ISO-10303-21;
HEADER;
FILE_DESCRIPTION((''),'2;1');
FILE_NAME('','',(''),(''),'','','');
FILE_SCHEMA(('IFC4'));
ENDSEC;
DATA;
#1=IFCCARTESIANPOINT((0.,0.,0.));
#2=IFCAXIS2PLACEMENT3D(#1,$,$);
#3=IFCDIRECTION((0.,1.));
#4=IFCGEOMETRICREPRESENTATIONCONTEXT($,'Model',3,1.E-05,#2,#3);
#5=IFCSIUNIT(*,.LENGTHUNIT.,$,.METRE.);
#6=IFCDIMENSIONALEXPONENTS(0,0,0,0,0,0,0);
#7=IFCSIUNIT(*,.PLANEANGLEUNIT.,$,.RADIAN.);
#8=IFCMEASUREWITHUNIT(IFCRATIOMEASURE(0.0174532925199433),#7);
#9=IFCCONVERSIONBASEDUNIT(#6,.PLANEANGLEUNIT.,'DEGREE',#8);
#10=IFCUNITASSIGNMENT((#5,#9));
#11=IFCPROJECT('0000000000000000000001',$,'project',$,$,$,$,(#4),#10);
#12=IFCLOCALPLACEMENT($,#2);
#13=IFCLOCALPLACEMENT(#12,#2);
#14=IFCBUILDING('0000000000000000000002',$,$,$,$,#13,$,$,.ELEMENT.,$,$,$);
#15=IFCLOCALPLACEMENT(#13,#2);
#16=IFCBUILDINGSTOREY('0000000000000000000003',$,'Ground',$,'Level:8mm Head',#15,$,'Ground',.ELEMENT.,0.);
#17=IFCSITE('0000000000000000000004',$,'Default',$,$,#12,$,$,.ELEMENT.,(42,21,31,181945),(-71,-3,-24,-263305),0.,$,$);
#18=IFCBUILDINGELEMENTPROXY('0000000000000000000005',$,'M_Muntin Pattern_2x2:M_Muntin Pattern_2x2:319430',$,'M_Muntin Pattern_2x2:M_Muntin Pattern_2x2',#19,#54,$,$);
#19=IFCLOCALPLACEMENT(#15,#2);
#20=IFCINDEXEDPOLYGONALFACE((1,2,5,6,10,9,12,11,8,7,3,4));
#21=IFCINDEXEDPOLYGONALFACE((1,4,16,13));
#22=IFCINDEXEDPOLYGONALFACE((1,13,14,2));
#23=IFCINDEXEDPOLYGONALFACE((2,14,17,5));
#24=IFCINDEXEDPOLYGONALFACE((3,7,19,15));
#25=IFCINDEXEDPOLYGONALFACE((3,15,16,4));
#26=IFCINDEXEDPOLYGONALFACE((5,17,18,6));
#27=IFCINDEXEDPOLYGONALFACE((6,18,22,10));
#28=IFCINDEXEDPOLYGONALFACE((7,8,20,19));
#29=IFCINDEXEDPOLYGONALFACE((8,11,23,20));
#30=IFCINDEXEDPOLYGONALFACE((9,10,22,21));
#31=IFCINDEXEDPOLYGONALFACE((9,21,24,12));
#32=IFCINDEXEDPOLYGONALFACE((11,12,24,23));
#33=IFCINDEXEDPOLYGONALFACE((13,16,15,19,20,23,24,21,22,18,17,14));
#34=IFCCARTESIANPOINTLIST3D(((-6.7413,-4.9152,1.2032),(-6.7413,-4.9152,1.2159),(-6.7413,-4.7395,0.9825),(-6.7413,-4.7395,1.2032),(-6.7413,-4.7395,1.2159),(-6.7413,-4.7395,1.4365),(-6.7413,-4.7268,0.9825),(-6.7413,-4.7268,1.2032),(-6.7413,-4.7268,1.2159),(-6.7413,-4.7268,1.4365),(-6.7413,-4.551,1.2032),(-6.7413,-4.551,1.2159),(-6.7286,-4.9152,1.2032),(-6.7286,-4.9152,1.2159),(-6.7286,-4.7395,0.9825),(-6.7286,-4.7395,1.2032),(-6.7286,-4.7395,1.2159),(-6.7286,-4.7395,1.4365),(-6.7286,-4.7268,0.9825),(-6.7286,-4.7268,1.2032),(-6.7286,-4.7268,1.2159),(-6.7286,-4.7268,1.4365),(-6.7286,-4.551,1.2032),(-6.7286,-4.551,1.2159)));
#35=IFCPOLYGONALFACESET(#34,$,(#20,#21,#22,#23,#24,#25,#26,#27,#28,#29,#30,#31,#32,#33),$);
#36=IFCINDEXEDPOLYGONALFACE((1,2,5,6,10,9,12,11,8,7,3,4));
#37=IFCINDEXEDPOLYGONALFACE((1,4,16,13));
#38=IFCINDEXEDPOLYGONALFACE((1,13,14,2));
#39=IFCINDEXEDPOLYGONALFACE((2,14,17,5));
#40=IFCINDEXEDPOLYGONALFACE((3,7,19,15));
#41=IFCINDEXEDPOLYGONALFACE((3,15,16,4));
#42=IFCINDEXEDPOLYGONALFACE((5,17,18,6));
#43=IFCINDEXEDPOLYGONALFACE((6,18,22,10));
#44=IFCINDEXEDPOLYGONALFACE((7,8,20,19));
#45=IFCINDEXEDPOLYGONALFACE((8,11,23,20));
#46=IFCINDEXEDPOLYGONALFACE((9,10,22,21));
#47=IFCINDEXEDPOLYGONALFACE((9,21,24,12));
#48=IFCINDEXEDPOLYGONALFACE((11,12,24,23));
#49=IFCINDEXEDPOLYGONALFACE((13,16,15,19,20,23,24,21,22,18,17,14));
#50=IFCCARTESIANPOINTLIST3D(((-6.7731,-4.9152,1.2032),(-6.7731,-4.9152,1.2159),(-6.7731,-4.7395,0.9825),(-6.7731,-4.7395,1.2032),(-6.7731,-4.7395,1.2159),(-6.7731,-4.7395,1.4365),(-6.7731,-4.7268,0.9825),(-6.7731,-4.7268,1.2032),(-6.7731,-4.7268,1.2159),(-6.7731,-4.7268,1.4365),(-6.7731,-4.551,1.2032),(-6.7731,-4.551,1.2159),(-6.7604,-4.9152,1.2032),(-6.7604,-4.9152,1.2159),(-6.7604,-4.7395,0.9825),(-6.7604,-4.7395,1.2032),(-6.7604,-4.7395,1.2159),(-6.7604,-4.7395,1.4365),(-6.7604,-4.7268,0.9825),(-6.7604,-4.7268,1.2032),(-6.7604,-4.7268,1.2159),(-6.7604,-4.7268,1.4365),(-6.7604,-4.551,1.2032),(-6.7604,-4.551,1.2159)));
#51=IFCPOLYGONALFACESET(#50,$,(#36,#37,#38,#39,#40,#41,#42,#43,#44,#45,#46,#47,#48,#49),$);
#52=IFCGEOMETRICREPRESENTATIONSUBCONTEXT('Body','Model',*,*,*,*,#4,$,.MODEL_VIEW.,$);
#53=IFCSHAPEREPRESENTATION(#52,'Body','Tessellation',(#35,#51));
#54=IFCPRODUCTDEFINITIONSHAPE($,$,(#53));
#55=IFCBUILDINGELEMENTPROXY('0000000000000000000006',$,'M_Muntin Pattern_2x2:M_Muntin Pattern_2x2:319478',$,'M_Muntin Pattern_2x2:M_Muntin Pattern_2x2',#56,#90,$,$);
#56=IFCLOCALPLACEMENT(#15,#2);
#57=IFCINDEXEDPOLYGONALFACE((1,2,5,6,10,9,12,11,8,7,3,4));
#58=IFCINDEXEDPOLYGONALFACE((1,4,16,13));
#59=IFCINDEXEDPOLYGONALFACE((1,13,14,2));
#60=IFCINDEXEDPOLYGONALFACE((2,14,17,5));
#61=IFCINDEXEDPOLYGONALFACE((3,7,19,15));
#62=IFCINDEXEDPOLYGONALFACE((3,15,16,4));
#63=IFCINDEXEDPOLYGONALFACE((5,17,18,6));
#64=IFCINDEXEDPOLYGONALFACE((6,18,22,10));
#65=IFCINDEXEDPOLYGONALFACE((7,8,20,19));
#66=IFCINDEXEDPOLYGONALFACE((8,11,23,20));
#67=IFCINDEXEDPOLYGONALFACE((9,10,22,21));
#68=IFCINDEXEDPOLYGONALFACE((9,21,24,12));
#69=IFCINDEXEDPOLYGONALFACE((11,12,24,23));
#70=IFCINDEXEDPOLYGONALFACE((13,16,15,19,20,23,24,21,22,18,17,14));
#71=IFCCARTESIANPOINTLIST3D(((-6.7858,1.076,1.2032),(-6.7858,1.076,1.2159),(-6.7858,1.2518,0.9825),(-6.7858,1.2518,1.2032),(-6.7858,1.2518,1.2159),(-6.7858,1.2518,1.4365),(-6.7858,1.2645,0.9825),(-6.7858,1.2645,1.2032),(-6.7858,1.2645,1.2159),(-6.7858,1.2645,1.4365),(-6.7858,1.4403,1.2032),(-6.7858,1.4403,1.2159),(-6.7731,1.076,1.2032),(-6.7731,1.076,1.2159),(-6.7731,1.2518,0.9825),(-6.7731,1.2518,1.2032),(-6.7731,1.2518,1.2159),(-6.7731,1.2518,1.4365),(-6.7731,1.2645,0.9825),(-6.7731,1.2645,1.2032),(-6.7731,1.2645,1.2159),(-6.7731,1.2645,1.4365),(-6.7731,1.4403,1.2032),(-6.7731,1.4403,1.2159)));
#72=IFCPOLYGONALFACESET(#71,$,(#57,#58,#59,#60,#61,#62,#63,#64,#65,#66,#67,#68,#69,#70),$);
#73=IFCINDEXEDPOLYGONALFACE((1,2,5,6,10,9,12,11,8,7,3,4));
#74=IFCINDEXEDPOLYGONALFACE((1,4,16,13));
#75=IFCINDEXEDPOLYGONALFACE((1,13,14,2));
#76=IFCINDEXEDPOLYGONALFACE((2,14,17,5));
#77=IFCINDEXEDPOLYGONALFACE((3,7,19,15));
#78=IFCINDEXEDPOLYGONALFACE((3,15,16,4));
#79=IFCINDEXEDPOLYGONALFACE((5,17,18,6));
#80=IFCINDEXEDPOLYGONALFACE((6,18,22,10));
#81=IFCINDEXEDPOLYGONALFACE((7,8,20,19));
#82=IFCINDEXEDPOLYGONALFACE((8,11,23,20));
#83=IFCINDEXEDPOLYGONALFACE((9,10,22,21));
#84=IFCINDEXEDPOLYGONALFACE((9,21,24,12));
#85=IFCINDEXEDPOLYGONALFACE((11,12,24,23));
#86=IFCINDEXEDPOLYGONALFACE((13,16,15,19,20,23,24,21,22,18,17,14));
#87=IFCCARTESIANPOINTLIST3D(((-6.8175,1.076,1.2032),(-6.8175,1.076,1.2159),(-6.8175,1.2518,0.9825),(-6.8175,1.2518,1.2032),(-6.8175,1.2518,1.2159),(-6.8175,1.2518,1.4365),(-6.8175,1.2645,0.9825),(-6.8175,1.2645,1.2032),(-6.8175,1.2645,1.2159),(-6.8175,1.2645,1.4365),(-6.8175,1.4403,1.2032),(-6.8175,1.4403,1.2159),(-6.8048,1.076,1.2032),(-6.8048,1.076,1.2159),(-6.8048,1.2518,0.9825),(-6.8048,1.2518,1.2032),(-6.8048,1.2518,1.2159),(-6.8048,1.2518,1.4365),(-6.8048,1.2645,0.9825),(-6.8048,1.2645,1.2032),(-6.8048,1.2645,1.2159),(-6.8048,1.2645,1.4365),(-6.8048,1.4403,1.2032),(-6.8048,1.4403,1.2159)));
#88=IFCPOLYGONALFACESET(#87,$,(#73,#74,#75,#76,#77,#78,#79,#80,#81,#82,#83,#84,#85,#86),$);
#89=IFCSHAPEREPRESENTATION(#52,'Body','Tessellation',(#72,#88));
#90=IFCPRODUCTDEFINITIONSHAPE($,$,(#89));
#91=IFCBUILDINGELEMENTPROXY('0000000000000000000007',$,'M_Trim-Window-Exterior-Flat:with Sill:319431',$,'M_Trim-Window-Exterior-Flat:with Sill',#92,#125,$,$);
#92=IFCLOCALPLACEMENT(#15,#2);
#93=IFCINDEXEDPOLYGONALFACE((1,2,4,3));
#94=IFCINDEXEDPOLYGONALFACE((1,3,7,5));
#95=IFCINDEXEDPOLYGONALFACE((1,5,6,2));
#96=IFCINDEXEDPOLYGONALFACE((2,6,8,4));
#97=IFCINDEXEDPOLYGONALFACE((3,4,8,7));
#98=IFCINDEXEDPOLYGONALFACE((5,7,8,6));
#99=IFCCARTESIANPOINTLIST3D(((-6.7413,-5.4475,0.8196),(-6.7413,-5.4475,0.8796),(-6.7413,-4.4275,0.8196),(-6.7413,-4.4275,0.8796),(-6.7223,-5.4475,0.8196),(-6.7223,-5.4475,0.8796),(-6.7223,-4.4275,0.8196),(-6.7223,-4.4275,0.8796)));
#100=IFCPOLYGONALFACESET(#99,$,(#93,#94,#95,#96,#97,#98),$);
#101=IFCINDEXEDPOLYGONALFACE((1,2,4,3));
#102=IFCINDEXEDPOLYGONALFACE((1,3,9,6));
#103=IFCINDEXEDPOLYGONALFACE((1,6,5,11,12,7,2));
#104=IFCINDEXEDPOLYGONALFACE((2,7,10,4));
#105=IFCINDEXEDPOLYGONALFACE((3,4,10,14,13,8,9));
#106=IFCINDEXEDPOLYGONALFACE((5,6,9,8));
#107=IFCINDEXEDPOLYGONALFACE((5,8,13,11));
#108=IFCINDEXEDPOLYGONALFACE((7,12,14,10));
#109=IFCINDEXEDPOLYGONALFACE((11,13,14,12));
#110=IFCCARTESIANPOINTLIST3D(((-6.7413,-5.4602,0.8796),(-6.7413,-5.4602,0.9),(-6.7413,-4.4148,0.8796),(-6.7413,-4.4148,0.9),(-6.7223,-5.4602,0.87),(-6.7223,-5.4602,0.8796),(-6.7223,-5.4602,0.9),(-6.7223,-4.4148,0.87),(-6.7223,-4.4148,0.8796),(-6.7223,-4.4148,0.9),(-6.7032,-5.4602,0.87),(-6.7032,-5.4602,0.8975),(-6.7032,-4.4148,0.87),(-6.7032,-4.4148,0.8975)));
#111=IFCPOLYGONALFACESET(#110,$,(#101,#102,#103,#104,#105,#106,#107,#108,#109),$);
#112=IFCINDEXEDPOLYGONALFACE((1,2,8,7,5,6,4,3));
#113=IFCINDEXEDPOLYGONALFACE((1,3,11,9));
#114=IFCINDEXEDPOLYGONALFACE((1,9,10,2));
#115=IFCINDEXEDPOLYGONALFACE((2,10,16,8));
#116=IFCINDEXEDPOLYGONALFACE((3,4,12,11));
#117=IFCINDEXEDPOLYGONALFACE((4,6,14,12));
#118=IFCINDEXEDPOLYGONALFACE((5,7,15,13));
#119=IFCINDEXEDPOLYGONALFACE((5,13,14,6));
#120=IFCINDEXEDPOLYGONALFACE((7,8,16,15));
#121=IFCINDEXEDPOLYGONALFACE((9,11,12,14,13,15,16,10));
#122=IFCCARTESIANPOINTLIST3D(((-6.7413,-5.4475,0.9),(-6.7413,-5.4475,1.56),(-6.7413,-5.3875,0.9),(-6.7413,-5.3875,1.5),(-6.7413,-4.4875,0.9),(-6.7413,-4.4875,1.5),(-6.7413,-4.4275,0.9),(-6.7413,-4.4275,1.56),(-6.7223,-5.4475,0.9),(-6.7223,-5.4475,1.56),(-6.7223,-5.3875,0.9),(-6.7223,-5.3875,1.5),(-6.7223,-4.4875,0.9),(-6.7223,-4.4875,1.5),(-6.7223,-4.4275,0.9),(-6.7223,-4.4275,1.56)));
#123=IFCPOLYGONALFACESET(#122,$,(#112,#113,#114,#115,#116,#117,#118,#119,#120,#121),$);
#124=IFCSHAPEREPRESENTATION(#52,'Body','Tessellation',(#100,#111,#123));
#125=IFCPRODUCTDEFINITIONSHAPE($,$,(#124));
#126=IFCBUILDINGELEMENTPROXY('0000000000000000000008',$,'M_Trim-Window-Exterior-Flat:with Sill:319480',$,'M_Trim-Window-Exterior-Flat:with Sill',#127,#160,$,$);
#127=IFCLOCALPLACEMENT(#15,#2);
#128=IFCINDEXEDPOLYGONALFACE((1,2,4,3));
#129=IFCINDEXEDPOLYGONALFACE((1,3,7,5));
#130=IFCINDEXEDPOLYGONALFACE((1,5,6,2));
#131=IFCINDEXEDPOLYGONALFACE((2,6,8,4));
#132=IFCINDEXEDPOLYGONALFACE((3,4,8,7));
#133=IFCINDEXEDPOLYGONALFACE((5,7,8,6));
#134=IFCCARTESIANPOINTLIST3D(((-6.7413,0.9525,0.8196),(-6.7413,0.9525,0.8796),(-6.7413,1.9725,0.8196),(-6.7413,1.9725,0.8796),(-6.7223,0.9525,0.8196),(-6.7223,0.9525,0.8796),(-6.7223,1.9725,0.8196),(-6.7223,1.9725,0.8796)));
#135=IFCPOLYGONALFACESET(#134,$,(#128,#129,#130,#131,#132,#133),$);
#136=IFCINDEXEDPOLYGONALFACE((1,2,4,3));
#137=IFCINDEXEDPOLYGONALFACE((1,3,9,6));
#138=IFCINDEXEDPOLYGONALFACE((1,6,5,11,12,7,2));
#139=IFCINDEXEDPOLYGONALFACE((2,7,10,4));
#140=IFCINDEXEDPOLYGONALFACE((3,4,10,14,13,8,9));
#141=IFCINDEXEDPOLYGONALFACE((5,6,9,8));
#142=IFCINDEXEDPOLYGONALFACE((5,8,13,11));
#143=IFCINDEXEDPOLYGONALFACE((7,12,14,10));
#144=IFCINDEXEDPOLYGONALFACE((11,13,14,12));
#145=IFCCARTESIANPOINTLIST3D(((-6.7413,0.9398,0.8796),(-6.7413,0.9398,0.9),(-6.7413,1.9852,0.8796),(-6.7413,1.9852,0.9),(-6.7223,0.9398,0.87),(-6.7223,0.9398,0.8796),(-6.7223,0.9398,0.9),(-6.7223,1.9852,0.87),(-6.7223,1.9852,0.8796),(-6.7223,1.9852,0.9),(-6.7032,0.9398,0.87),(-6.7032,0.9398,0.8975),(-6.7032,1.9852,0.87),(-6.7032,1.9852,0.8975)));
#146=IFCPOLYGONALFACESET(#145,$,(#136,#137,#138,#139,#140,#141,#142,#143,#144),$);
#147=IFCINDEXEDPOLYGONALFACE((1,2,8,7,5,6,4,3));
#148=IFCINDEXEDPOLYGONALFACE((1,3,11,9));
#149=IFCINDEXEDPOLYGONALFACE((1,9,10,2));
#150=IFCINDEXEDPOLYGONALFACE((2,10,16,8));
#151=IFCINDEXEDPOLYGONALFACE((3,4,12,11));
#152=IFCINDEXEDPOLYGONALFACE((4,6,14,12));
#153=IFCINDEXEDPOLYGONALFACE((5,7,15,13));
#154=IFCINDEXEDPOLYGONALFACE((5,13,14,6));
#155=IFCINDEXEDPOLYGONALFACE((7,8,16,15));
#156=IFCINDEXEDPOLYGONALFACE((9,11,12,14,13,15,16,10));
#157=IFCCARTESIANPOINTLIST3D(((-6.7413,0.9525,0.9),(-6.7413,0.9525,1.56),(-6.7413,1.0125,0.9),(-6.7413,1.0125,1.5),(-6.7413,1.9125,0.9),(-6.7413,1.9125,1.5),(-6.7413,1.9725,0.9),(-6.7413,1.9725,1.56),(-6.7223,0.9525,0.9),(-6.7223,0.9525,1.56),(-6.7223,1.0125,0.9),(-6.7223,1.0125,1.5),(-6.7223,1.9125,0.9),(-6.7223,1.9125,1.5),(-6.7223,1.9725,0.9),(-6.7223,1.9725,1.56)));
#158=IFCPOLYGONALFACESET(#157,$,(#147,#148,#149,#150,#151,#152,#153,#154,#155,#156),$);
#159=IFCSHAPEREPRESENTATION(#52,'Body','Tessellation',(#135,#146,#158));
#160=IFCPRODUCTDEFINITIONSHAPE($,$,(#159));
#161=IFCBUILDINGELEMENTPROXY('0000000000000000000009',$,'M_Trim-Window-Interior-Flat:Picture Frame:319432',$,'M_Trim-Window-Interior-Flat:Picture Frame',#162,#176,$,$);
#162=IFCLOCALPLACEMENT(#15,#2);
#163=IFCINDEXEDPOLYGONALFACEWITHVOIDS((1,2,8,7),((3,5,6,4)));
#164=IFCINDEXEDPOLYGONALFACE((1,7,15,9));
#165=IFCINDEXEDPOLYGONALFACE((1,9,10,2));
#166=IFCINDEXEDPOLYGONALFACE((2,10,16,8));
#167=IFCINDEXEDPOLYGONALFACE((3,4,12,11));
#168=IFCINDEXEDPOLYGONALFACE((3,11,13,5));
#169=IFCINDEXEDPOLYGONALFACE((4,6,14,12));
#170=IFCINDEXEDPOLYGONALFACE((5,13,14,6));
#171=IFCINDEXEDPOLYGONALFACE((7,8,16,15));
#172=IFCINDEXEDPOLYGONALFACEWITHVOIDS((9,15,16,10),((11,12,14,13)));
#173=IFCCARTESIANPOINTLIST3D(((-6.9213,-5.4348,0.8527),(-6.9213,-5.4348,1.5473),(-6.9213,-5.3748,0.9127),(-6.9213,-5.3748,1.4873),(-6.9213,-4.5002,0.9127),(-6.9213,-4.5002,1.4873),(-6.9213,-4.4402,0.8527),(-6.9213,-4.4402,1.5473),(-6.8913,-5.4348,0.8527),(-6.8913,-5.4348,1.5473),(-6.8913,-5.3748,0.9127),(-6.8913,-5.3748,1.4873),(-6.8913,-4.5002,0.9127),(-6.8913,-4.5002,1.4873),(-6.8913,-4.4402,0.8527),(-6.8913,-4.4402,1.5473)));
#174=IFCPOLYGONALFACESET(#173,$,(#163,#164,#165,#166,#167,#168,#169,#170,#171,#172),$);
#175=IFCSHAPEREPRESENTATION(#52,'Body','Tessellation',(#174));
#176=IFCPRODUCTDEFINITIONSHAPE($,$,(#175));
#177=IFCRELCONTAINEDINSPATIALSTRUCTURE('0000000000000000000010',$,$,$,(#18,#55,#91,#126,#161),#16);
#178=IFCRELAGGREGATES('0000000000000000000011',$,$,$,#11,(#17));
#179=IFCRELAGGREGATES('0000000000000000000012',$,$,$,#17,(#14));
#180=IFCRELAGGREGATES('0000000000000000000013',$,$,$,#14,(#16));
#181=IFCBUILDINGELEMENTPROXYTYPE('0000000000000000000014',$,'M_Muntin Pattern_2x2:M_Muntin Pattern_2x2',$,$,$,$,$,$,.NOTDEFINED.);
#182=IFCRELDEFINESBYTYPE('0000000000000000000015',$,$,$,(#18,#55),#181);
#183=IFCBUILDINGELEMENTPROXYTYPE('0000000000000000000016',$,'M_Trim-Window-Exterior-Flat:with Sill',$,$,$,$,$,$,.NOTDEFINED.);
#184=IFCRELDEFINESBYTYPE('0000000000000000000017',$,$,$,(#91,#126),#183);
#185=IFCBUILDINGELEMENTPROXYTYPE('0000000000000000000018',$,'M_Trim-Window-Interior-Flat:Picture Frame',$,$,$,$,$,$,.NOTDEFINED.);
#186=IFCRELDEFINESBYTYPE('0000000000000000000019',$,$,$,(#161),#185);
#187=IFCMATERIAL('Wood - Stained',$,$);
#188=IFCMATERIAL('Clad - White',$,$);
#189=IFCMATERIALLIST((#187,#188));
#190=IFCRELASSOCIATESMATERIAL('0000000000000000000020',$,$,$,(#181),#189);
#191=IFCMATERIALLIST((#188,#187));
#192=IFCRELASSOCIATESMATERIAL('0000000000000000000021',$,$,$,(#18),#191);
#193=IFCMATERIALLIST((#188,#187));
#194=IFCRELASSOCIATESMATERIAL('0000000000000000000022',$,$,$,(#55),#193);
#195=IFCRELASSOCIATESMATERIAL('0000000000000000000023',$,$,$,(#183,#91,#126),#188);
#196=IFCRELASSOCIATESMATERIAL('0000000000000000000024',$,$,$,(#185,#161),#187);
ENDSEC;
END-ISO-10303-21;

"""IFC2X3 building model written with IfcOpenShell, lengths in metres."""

from ifc_helpers import new_model, entity, si_unit, converted_unit, direction, frame, frame_2d, origin, place, context, subcontext, project, spatial, polyline, rectangle, outline, extrude, source, transform, mapped, material, material_list, type_object, type_shapes, element, save


model = new_model("IFC2X3")

# Units and contexts
model_context = context("Model", 3, precision=1e-05, world=origin(), true_north=direction((0.0, 1.0)))
body_context = subcontext(model_context, "Body", "Model", "MODEL_VIEW")
ifc_project = project(units=[si_unit("LENGTHUNIT", "METRE"), converted_unit("PLANEANGLEUNIT", "DEGREE", entity("IfcRatioMeasure", 0.0174532925199433), si_unit("PLANEANGLEUNIT", "RADIAN"), dimensions=[0, 0, 0, 0, 0, 0, 0])], contexts=[model_context])

# Site, building, storey
site_placement = place(None, origin())
site = spatial("IfcSite", under=ifc_project, at=site_placement, Name="Default", CompositionType="ELEMENT", RefLatitude=(42, 21, 31, 181945), RefLongitude=(-71, -3, -24, -263305), RefElevation=0.0)
building_placement = place(site_placement, origin())
building = spatial("IfcBuilding", under=site, at=building_placement, CompositionType="ELEMENT")
storey_placement = place(building_placement, origin())
storey = spatial("IfcBuildingStorey", under=building, at=storey_placement, Name="Ground", ObjectType="Level:8mm Head", LongName="Ground", CompositionType="ELEMENT", Elevation=0.0)

# Building element proxies
ifc_material_1 = material(Name="Clad - White")
ifc_material_2 = material(Name="Wood - Stained")
ifc_material_list_1 = material_list([ifc_material_2, ifc_material_1])
building_element_proxy_type_1 = type_object("IfcBuildingElementProxyType", Name="M_Muntin Pattern_2x2:M_Muntin Pattern_2x2", PredefinedType="NOTDEFINED", material=ifc_material_list_1)
shared_shape_1 = source(origin(), body_context, "Body", "SweptSolid", [
    extrude(outline(polyline([(0.0064, -0.0064), (0.227, -0.0064), (0.227, 0.0063), (0.0064, 0.0063), (0.0064, 0.1821), (-0.0063, 0.1821), (-0.0063, 0.0063), (-0.227, 0.0063), (-0.227, -0.0064), (-0.0063, -0.0064), (-0.0063, -0.1821), (0.0064, -0.1821), (0.0064, -0.0064)])), frame((0.0, 0.0095, 0.227), z_axis=(0.0, 1.0, 0.0), x_axis=(0.0, 0.0, 1.0)), (0.0, 0.0, 1.0), 0.0127),
    extrude(outline(polyline([(0.0064, -0.0064), (0.227, -0.0064), (0.227, 0.0063), (0.0064, 0.0063), (0.0064, 0.1821), (-0.0063, 0.1821), (-0.0063, 0.0063), (-0.227, 0.0063), (-0.227, -0.0064), (-0.0063, -0.0064), (-0.0063, -0.1821), (0.0064, -0.1821), (0.0064, -0.0064)])), frame((0.0, -0.0222, 0.227), z_axis=(0.0, 1.0, 0.0), x_axis=(0.0, 0.0, 1.0)), (0.0, 0.0, 1.0), 0.0127),
])
type_shapes(building_element_proxy_type_1, [shared_shape_1])
ifc_material_list_2 = material_list([ifc_material_1, ifc_material_2])
proxy_1_placement = place(storey_placement, frame((-6.7509, -4.7331, 0.9825), z_axis=(0.0, 0.0, 1.0), x_axis=(0.0, -1.0, 0.0)))
element("IfcBuildingElementProxy", 1, at=proxy_1_placement, inside=storey, type_object=building_element_proxy_type_1, material=ifc_material_list_2, Name="M_Muntin Pattern_2x2:M_Muntin Pattern_2x2:319430", ObjectType="M_Muntin Pattern_2x2:M_Muntin Pattern_2x2", context=body_context, shape_type="MappedRepresentation", body=[
    mapped(shared_shape_1, transform((0.0, 0.0, 0.0), scale=1.0)),
])
ifc_material_list_3 = material_list([ifc_material_1, ifc_material_2])
proxy_2_placement = place(storey_placement, frame((-6.7953, 1.2582, 0.9825), z_axis=(0.0, 0.0, 1.0), x_axis=(0.0, -1.0, 0.0)))
element("IfcBuildingElementProxy", 2, at=proxy_2_placement, inside=storey, type_object=building_element_proxy_type_1, material=ifc_material_list_3, Name="M_Muntin Pattern_2x2:M_Muntin Pattern_2x2:319478", ObjectType="M_Muntin Pattern_2x2:M_Muntin Pattern_2x2", context=body_context, shape_type="MappedRepresentation", body=[
    mapped(shared_shape_1, transform((0.0, 0.0, 0.0), scale=1.0)),
])
building_element_proxy_type_2 = type_object("IfcBuildingElementProxyType", Name="M_Trim-Window-Exterior-Flat:with Sill", PredefinedType="NOTDEFINED", material=ifc_material_1)
shared_shape_2 = source(origin(), body_context, "Body", "SweptSolid", [
    extrude(rectangle(XDim=1.02, YDim=0.06, at=frame_2d((0.0, 0.0), x_axis=(1.0, 0.0))), frame((0.0, -0.6504, 0.0), z_axis=(0.0, 0.0, 1.0), x_axis=(-1.0, 0.0, 0.0)), (0.0, 0.0, 1.0), 0.0191),
    extrude(outline(polyline([(-0.019, -0.0152), (0.0, -0.0152), (0.0, -0.0057), (0.019, -0.0057), (0.019, 0.0148), (0.0, 0.0148), (-0.019, 0.0123), (-0.019, -0.0152)])), frame((-0.5227, -0.6148, 0.019), z_axis=(1.0, 0.0, 0.0), x_axis=(0.0, 0.0, -1.0)), (0.0, 0.0, 1.0), 1.0454),
    extrude(outline(polyline([(-0.345, -0.51), (0.315, -0.51), (0.315, -0.45), (-0.285, -0.45), (-0.285, 0.45), (0.315, 0.45), (0.315, 0.51), (-0.345, 0.51), (-0.345, -0.51)])), frame((0.0, -0.285, 0.0), z_axis=(0.0, 0.0, 1.0), x_axis=(0.0, -1.0, 0.0)), (0.0, 0.0, 1.0), 0.0191),
])
type_shapes(building_element_proxy_type_2, [shared_shape_2])
for number, where, z_axis, x_axis, name in (
    (3, (-6.7413, -4.9375, 1.5), (1.0, 0.0, 0.0), (0.0, 1.0, 0.0), "M_Trim-Window-Exterior-Flat:with Sill:319431"),
    (4, (-6.7413, 1.4625, 1.5), (1.0, 0.0, 0.0), (0.0, 1.0, 0.0), "M_Trim-Window-Exterior-Flat:with Sill:319480"),
):
    element("IfcBuildingElementProxy", number, at=place(storey_placement, frame(where, z_axis=z_axis, x_axis=x_axis)), inside=storey, type_object=building_element_proxy_type_2, material=ifc_material_1, Name=name, ObjectType="M_Trim-Window-Exterior-Flat:with Sill", context=body_context, shape_type="MappedRepresentation", body=[
        mapped(shared_shape_2, transform((0.0, 0.0, 0.0), scale=1.0)),
    ])
building_element_proxy_type_3 = type_object("IfcBuildingElementProxyType", Name="M_Trim-Window-Interior-Flat:Picture Frame", PredefinedType="NOTDEFINED", material=ifc_material_2)
shared_shape_3 = source(origin(), body_context, "Body", "SweptSolid", [
    extrude(outline(polyline([(-0.4973, -0.3473), (0.4973, -0.3473), (0.4973, 0.3473), (-0.4973, 0.3473), (-0.4973, -0.3473)]), holes=[polyline([(-0.4373, -0.2873), (-0.4373, 0.2873), (0.4373, 0.2873), (0.4373, -0.2873), (-0.4373, -0.2873)])]), frame((0.0, -0.3, 0.0), z_axis=(0.0, 0.0, 1.0), x_axis=(-1.0, 0.0, 0.0)), (0.0, 0.0, 1.0), 0.03),
])
type_shapes(building_element_proxy_type_3, [shared_shape_3])
proxy_3_placement = place(storey_placement, frame((-6.8913, -4.9375, 1.5), z_axis=(-1.0, 0.0, 0.0), x_axis=(0.0, -1.0, 0.0)))
element("IfcBuildingElementProxy", 5, at=proxy_3_placement, inside=storey, type_object=building_element_proxy_type_3, material=ifc_material_2, Name="M_Trim-Window-Interior-Flat:Picture Frame:319432", ObjectType="M_Trim-Window-Interior-Flat:Picture Frame", context=body_context, shape_type="MappedRepresentation", body=[
    mapped(shared_shape_3, transform((0.0, 0.0, 0.0), scale=1.0)),
])

save(model, "model.ifc")
